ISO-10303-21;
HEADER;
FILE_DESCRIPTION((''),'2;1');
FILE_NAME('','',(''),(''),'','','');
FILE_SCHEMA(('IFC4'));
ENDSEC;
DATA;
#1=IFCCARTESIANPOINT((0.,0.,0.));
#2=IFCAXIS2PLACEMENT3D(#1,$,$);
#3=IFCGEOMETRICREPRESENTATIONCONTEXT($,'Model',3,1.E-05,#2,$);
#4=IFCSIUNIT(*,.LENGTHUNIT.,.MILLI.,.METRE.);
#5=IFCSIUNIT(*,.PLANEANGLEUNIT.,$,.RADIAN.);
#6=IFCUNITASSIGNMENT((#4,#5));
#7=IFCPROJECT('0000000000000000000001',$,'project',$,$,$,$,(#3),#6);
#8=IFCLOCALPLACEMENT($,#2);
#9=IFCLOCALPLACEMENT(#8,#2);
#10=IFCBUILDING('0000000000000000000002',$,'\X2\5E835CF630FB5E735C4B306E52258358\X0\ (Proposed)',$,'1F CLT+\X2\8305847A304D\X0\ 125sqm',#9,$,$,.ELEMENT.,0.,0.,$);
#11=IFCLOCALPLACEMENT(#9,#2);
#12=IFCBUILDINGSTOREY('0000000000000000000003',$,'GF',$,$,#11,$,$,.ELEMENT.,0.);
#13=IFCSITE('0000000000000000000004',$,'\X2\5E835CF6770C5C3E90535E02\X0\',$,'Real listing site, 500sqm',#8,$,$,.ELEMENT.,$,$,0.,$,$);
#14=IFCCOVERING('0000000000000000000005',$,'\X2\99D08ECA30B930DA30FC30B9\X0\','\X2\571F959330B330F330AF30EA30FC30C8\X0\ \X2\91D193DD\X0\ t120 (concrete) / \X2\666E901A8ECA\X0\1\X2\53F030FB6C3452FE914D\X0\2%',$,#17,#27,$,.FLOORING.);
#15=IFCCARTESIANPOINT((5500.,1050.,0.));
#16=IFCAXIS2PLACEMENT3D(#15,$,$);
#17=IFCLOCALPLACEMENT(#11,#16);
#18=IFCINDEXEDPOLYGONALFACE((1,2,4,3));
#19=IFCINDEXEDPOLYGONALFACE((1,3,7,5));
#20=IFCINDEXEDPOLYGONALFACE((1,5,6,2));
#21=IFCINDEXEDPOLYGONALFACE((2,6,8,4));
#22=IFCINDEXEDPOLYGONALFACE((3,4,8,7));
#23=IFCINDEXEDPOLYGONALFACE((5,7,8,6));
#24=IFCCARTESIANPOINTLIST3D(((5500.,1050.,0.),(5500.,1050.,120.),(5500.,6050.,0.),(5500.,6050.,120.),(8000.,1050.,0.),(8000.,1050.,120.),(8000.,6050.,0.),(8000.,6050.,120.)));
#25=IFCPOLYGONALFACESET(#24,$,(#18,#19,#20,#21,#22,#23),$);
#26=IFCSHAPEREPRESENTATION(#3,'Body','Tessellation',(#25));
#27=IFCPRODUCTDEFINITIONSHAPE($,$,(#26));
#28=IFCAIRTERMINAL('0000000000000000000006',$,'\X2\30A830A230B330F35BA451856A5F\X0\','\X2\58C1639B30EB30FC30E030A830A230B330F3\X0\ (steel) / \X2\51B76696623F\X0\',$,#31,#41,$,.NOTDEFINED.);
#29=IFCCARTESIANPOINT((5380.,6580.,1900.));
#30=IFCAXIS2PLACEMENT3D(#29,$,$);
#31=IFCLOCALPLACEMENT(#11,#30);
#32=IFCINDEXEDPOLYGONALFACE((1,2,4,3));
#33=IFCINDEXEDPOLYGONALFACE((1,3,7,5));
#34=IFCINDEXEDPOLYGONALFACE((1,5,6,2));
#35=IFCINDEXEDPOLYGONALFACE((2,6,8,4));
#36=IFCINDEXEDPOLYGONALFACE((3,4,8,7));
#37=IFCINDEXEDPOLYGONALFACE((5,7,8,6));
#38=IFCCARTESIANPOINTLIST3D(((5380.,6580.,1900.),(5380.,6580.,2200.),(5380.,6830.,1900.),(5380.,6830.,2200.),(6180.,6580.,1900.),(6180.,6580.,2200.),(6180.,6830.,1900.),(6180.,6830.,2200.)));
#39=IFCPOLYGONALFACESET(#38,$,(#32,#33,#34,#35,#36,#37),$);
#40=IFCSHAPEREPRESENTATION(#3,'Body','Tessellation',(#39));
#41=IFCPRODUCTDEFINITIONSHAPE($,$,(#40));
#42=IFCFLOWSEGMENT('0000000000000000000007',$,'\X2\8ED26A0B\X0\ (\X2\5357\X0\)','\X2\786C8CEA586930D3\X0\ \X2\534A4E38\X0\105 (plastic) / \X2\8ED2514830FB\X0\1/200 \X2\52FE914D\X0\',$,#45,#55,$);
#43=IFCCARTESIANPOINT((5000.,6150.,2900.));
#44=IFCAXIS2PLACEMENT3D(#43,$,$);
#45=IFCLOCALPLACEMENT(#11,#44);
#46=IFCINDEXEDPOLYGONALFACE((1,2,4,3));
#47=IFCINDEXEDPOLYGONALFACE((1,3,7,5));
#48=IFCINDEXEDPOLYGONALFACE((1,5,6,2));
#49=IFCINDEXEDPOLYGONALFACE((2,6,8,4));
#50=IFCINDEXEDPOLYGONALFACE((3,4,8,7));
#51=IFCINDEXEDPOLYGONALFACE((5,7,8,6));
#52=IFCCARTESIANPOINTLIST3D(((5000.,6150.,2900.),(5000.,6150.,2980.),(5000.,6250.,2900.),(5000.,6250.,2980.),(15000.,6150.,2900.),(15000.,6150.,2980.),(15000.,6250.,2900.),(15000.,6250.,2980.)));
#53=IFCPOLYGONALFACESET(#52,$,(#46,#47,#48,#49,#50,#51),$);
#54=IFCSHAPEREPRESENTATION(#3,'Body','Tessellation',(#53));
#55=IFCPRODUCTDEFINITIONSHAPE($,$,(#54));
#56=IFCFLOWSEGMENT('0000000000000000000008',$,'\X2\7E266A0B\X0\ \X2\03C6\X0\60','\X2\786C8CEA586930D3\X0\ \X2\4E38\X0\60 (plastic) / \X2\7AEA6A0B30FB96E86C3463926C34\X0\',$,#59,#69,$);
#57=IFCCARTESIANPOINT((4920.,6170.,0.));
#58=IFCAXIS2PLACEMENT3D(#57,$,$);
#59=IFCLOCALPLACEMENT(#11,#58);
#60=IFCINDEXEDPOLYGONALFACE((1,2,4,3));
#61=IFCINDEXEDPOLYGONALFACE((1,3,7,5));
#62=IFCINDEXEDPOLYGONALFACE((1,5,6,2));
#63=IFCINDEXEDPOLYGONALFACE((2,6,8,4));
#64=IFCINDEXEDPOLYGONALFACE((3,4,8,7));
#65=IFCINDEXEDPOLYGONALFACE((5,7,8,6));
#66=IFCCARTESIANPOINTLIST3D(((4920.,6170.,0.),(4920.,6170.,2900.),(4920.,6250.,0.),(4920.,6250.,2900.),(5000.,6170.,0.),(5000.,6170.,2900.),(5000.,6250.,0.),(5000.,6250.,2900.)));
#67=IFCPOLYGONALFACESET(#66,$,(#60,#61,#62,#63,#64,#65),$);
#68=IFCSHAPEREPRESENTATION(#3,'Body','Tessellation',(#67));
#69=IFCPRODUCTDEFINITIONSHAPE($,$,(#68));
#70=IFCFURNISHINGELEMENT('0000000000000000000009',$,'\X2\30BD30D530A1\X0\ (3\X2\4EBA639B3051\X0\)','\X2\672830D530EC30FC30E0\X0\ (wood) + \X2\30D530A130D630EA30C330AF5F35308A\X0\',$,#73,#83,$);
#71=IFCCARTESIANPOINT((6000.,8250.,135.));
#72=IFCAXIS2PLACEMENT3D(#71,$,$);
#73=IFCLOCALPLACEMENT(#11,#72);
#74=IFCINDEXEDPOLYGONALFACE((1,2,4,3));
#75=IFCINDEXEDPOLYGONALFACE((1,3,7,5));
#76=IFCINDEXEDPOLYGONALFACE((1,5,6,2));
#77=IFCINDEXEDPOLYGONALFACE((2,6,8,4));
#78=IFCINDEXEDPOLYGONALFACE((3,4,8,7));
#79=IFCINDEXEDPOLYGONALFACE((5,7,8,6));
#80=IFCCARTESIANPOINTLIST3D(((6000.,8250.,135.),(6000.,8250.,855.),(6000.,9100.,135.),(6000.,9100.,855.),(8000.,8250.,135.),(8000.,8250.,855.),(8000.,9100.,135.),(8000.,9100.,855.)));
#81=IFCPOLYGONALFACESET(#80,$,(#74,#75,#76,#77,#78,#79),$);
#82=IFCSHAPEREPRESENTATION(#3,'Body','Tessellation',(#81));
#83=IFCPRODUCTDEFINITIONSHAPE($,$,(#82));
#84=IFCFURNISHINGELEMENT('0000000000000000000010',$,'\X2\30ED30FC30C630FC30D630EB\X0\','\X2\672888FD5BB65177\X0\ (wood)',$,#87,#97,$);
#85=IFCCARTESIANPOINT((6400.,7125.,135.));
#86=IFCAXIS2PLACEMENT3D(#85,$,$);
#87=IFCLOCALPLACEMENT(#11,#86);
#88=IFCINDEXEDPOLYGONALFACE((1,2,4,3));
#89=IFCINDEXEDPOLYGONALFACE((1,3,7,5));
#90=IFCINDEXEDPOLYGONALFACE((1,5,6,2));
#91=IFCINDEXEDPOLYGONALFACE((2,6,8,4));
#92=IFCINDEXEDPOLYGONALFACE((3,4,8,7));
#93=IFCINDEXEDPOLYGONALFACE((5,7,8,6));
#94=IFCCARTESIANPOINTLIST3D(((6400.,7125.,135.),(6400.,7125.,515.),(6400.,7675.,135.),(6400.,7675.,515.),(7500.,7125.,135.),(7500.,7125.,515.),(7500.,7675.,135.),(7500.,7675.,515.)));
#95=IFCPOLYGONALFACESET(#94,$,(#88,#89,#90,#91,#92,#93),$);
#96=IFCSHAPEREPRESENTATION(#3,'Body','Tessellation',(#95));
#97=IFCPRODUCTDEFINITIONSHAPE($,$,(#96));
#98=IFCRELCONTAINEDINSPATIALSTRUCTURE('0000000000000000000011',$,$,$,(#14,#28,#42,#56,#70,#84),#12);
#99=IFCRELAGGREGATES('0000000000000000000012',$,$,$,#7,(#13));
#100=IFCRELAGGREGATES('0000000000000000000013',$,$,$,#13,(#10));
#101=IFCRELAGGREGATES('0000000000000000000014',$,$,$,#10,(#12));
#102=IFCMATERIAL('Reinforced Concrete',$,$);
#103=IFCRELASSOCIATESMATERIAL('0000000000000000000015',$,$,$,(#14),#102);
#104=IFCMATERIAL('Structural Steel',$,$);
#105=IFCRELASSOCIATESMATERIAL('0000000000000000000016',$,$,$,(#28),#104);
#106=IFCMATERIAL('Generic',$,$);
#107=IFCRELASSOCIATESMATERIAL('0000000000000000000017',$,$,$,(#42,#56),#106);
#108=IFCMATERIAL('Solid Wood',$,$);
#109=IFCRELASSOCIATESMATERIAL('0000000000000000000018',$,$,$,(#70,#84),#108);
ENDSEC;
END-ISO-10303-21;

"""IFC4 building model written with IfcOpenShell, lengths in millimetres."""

from ifc_helpers import new_model, si_unit, frame, frame_2d, origin, place, context, project, spatial, rectangle, extrude, material, element, save


model = new_model("IFC4")

# Units and contexts
model_context = context("Model", 3, precision=1e-05, world=origin())
ifc_project = project(units=[si_unit("LENGTHUNIT", "METRE", prefix="MILLI"), si_unit("PLANEANGLEUNIT", "RADIAN")], contexts=[model_context])

# Site, building, storey
site_placement = place(None, origin())
site = spatial("IfcSite", under=ifc_project, at=site_placement, Name="広島県尾道市", ObjectType="Real listing site, 500sqm", CompositionType="ELEMENT", RefElevation=0.0)
building_placement = place(site_placement, origin())
building = spatial("IfcBuilding", under=site, at=building_placement, Name="広島・平屋の別荘 (Proposed)", ObjectType="1F CLT+茅葺き 125sqm", CompositionType="ELEMENT", ElevationOfRefHeight=0.0, ElevationOfTerrain=0.0)
storey_placement = place(building_placement, origin())
storey = spatial("IfcBuildingStorey", under=building, at=storey_placement, Name="GF", CompositionType="ELEMENT", Elevation=0.0)

# Shared definitions
ifc_material_1 = material(Name="Solid Wood")

# Shared definitions
ifc_material_2 = material(Name="Reinforced Concrete")

# Shared definitions
ifc_material_3 = material(Name="Structural Steel")

# Covering
ifc_material_4 = material(Name="Generic")
covering_1_placement = place(storey_placement, frame((5500.0, 1050.0, 0.0)))
element("IfcCovering", 1, at=covering_1_placement, inside=storey, material=ifc_material_2, Name="駐車スペース", Description="土間コンクリート 金鏝 t120 (concrete) / 普通車1台・水勾配2%", PredefinedType="FLOORING", context=model_context, shape_type="SweptSolid", body=[
    extrude(rectangle(XDim=2500.0, YDim=5000.0, at=frame_2d((1250.0, 2500.0))), frame((5500.0, 1050.0, 0.0)), (0.0, 0.0, 1.0), 120.0),
])

# Air terminal
air_terminal_placement = place(storey_placement, frame((5380.0, 6580.0, 1900.0)))
element("IfcAirTerminal", 2, at=air_terminal_placement, inside=storey, material=ifc_material_3, Name="エアコン室内機", Description="壁掛ルームエアコン (steel) / 冷暖房", PredefinedType="NOTDEFINED", context=model_context, shape_type="SweptSolid", body=[
    extrude(rectangle(XDim=800.0, YDim=250.0, at=frame_2d((400.0, 125.0))), frame((5380.0, 6580.0, 1900.0)), (0.0, 0.0, 1.0), 300.0),
])

# Flow segments
flow_segment_1_placement = place(storey_placement, frame((5000.0, 6150.0, 2900.0)))
element("IfcFlowSegment", 3, at=flow_segment_1_placement, inside=storey, material=ifc_material_4, Name="軒樋 (南)", Description="硬質塩ビ 半丸105 (plastic) / 軒先・1/200 勾配", context=model_context, shape_type="SweptSolid", body=[
    extrude(rectangle(XDim=10000.0, YDim=100.0, at=frame_2d((5000.0, 50.0))), frame((5000.0, 6150.0, 2900.0)), (0.0, 0.0, 1.0), 80.0),
])
flow_segment_2_placement = place(storey_placement, frame((4920.0, 6170.0, 0.0)))
element("IfcFlowSegment", 4, at=flow_segment_2_placement, inside=storey, material=ifc_material_4, Name="縦樋 φ60", Description="硬質塩ビ 丸60 (plastic) / 竪樋・雨水排水", context=model_context, shape_type="SweptSolid", body=[
    extrude(rectangle(XDim=80.0, YDim=80.0, at=frame_2d((40.0, 40.0))), frame((4920.0, 6170.0, 0.0)), (0.0, 0.0, 1.0), 2900.0),
])

# Furnishing elements
furnishing_1_placement = place(storey_placement, frame((6000.0, 8250.0, 135.0)))
element("IfcFurnishingElement", 5, at=furnishing_1_placement, inside=storey, material=ifc_material_1, Name="ソファ (3人掛け)", Description="木フレーム (wood) + ファブリック張り", context=model_context, shape_type="SweptSolid", body=[
    extrude(rectangle(XDim=2000.0, YDim=850.0, at=frame_2d((1000.0, 425.0))), frame((6000.0, 8250.0, 135.0)), (0.0, 0.0, 1.0), 720.0),
])
furnishing_2_placement = place(storey_placement, frame((6400.0, 7125.0, 135.0)))
element("IfcFurnishingElement", 6, at=furnishing_2_placement, inside=storey, material=ifc_material_1, Name="ローテーブル", Description="木製家具 (wood)", context=model_context, shape_type="SweptSolid", body=[
    extrude(rectangle(XDim=1100.0, YDim=550.0, at=frame_2d((550.0, 275.0))), frame((6400.0, 7125.0, 135.0)), (0.0, 0.0, 1.0), 380.0),
])

save(model, "model.ifc")
